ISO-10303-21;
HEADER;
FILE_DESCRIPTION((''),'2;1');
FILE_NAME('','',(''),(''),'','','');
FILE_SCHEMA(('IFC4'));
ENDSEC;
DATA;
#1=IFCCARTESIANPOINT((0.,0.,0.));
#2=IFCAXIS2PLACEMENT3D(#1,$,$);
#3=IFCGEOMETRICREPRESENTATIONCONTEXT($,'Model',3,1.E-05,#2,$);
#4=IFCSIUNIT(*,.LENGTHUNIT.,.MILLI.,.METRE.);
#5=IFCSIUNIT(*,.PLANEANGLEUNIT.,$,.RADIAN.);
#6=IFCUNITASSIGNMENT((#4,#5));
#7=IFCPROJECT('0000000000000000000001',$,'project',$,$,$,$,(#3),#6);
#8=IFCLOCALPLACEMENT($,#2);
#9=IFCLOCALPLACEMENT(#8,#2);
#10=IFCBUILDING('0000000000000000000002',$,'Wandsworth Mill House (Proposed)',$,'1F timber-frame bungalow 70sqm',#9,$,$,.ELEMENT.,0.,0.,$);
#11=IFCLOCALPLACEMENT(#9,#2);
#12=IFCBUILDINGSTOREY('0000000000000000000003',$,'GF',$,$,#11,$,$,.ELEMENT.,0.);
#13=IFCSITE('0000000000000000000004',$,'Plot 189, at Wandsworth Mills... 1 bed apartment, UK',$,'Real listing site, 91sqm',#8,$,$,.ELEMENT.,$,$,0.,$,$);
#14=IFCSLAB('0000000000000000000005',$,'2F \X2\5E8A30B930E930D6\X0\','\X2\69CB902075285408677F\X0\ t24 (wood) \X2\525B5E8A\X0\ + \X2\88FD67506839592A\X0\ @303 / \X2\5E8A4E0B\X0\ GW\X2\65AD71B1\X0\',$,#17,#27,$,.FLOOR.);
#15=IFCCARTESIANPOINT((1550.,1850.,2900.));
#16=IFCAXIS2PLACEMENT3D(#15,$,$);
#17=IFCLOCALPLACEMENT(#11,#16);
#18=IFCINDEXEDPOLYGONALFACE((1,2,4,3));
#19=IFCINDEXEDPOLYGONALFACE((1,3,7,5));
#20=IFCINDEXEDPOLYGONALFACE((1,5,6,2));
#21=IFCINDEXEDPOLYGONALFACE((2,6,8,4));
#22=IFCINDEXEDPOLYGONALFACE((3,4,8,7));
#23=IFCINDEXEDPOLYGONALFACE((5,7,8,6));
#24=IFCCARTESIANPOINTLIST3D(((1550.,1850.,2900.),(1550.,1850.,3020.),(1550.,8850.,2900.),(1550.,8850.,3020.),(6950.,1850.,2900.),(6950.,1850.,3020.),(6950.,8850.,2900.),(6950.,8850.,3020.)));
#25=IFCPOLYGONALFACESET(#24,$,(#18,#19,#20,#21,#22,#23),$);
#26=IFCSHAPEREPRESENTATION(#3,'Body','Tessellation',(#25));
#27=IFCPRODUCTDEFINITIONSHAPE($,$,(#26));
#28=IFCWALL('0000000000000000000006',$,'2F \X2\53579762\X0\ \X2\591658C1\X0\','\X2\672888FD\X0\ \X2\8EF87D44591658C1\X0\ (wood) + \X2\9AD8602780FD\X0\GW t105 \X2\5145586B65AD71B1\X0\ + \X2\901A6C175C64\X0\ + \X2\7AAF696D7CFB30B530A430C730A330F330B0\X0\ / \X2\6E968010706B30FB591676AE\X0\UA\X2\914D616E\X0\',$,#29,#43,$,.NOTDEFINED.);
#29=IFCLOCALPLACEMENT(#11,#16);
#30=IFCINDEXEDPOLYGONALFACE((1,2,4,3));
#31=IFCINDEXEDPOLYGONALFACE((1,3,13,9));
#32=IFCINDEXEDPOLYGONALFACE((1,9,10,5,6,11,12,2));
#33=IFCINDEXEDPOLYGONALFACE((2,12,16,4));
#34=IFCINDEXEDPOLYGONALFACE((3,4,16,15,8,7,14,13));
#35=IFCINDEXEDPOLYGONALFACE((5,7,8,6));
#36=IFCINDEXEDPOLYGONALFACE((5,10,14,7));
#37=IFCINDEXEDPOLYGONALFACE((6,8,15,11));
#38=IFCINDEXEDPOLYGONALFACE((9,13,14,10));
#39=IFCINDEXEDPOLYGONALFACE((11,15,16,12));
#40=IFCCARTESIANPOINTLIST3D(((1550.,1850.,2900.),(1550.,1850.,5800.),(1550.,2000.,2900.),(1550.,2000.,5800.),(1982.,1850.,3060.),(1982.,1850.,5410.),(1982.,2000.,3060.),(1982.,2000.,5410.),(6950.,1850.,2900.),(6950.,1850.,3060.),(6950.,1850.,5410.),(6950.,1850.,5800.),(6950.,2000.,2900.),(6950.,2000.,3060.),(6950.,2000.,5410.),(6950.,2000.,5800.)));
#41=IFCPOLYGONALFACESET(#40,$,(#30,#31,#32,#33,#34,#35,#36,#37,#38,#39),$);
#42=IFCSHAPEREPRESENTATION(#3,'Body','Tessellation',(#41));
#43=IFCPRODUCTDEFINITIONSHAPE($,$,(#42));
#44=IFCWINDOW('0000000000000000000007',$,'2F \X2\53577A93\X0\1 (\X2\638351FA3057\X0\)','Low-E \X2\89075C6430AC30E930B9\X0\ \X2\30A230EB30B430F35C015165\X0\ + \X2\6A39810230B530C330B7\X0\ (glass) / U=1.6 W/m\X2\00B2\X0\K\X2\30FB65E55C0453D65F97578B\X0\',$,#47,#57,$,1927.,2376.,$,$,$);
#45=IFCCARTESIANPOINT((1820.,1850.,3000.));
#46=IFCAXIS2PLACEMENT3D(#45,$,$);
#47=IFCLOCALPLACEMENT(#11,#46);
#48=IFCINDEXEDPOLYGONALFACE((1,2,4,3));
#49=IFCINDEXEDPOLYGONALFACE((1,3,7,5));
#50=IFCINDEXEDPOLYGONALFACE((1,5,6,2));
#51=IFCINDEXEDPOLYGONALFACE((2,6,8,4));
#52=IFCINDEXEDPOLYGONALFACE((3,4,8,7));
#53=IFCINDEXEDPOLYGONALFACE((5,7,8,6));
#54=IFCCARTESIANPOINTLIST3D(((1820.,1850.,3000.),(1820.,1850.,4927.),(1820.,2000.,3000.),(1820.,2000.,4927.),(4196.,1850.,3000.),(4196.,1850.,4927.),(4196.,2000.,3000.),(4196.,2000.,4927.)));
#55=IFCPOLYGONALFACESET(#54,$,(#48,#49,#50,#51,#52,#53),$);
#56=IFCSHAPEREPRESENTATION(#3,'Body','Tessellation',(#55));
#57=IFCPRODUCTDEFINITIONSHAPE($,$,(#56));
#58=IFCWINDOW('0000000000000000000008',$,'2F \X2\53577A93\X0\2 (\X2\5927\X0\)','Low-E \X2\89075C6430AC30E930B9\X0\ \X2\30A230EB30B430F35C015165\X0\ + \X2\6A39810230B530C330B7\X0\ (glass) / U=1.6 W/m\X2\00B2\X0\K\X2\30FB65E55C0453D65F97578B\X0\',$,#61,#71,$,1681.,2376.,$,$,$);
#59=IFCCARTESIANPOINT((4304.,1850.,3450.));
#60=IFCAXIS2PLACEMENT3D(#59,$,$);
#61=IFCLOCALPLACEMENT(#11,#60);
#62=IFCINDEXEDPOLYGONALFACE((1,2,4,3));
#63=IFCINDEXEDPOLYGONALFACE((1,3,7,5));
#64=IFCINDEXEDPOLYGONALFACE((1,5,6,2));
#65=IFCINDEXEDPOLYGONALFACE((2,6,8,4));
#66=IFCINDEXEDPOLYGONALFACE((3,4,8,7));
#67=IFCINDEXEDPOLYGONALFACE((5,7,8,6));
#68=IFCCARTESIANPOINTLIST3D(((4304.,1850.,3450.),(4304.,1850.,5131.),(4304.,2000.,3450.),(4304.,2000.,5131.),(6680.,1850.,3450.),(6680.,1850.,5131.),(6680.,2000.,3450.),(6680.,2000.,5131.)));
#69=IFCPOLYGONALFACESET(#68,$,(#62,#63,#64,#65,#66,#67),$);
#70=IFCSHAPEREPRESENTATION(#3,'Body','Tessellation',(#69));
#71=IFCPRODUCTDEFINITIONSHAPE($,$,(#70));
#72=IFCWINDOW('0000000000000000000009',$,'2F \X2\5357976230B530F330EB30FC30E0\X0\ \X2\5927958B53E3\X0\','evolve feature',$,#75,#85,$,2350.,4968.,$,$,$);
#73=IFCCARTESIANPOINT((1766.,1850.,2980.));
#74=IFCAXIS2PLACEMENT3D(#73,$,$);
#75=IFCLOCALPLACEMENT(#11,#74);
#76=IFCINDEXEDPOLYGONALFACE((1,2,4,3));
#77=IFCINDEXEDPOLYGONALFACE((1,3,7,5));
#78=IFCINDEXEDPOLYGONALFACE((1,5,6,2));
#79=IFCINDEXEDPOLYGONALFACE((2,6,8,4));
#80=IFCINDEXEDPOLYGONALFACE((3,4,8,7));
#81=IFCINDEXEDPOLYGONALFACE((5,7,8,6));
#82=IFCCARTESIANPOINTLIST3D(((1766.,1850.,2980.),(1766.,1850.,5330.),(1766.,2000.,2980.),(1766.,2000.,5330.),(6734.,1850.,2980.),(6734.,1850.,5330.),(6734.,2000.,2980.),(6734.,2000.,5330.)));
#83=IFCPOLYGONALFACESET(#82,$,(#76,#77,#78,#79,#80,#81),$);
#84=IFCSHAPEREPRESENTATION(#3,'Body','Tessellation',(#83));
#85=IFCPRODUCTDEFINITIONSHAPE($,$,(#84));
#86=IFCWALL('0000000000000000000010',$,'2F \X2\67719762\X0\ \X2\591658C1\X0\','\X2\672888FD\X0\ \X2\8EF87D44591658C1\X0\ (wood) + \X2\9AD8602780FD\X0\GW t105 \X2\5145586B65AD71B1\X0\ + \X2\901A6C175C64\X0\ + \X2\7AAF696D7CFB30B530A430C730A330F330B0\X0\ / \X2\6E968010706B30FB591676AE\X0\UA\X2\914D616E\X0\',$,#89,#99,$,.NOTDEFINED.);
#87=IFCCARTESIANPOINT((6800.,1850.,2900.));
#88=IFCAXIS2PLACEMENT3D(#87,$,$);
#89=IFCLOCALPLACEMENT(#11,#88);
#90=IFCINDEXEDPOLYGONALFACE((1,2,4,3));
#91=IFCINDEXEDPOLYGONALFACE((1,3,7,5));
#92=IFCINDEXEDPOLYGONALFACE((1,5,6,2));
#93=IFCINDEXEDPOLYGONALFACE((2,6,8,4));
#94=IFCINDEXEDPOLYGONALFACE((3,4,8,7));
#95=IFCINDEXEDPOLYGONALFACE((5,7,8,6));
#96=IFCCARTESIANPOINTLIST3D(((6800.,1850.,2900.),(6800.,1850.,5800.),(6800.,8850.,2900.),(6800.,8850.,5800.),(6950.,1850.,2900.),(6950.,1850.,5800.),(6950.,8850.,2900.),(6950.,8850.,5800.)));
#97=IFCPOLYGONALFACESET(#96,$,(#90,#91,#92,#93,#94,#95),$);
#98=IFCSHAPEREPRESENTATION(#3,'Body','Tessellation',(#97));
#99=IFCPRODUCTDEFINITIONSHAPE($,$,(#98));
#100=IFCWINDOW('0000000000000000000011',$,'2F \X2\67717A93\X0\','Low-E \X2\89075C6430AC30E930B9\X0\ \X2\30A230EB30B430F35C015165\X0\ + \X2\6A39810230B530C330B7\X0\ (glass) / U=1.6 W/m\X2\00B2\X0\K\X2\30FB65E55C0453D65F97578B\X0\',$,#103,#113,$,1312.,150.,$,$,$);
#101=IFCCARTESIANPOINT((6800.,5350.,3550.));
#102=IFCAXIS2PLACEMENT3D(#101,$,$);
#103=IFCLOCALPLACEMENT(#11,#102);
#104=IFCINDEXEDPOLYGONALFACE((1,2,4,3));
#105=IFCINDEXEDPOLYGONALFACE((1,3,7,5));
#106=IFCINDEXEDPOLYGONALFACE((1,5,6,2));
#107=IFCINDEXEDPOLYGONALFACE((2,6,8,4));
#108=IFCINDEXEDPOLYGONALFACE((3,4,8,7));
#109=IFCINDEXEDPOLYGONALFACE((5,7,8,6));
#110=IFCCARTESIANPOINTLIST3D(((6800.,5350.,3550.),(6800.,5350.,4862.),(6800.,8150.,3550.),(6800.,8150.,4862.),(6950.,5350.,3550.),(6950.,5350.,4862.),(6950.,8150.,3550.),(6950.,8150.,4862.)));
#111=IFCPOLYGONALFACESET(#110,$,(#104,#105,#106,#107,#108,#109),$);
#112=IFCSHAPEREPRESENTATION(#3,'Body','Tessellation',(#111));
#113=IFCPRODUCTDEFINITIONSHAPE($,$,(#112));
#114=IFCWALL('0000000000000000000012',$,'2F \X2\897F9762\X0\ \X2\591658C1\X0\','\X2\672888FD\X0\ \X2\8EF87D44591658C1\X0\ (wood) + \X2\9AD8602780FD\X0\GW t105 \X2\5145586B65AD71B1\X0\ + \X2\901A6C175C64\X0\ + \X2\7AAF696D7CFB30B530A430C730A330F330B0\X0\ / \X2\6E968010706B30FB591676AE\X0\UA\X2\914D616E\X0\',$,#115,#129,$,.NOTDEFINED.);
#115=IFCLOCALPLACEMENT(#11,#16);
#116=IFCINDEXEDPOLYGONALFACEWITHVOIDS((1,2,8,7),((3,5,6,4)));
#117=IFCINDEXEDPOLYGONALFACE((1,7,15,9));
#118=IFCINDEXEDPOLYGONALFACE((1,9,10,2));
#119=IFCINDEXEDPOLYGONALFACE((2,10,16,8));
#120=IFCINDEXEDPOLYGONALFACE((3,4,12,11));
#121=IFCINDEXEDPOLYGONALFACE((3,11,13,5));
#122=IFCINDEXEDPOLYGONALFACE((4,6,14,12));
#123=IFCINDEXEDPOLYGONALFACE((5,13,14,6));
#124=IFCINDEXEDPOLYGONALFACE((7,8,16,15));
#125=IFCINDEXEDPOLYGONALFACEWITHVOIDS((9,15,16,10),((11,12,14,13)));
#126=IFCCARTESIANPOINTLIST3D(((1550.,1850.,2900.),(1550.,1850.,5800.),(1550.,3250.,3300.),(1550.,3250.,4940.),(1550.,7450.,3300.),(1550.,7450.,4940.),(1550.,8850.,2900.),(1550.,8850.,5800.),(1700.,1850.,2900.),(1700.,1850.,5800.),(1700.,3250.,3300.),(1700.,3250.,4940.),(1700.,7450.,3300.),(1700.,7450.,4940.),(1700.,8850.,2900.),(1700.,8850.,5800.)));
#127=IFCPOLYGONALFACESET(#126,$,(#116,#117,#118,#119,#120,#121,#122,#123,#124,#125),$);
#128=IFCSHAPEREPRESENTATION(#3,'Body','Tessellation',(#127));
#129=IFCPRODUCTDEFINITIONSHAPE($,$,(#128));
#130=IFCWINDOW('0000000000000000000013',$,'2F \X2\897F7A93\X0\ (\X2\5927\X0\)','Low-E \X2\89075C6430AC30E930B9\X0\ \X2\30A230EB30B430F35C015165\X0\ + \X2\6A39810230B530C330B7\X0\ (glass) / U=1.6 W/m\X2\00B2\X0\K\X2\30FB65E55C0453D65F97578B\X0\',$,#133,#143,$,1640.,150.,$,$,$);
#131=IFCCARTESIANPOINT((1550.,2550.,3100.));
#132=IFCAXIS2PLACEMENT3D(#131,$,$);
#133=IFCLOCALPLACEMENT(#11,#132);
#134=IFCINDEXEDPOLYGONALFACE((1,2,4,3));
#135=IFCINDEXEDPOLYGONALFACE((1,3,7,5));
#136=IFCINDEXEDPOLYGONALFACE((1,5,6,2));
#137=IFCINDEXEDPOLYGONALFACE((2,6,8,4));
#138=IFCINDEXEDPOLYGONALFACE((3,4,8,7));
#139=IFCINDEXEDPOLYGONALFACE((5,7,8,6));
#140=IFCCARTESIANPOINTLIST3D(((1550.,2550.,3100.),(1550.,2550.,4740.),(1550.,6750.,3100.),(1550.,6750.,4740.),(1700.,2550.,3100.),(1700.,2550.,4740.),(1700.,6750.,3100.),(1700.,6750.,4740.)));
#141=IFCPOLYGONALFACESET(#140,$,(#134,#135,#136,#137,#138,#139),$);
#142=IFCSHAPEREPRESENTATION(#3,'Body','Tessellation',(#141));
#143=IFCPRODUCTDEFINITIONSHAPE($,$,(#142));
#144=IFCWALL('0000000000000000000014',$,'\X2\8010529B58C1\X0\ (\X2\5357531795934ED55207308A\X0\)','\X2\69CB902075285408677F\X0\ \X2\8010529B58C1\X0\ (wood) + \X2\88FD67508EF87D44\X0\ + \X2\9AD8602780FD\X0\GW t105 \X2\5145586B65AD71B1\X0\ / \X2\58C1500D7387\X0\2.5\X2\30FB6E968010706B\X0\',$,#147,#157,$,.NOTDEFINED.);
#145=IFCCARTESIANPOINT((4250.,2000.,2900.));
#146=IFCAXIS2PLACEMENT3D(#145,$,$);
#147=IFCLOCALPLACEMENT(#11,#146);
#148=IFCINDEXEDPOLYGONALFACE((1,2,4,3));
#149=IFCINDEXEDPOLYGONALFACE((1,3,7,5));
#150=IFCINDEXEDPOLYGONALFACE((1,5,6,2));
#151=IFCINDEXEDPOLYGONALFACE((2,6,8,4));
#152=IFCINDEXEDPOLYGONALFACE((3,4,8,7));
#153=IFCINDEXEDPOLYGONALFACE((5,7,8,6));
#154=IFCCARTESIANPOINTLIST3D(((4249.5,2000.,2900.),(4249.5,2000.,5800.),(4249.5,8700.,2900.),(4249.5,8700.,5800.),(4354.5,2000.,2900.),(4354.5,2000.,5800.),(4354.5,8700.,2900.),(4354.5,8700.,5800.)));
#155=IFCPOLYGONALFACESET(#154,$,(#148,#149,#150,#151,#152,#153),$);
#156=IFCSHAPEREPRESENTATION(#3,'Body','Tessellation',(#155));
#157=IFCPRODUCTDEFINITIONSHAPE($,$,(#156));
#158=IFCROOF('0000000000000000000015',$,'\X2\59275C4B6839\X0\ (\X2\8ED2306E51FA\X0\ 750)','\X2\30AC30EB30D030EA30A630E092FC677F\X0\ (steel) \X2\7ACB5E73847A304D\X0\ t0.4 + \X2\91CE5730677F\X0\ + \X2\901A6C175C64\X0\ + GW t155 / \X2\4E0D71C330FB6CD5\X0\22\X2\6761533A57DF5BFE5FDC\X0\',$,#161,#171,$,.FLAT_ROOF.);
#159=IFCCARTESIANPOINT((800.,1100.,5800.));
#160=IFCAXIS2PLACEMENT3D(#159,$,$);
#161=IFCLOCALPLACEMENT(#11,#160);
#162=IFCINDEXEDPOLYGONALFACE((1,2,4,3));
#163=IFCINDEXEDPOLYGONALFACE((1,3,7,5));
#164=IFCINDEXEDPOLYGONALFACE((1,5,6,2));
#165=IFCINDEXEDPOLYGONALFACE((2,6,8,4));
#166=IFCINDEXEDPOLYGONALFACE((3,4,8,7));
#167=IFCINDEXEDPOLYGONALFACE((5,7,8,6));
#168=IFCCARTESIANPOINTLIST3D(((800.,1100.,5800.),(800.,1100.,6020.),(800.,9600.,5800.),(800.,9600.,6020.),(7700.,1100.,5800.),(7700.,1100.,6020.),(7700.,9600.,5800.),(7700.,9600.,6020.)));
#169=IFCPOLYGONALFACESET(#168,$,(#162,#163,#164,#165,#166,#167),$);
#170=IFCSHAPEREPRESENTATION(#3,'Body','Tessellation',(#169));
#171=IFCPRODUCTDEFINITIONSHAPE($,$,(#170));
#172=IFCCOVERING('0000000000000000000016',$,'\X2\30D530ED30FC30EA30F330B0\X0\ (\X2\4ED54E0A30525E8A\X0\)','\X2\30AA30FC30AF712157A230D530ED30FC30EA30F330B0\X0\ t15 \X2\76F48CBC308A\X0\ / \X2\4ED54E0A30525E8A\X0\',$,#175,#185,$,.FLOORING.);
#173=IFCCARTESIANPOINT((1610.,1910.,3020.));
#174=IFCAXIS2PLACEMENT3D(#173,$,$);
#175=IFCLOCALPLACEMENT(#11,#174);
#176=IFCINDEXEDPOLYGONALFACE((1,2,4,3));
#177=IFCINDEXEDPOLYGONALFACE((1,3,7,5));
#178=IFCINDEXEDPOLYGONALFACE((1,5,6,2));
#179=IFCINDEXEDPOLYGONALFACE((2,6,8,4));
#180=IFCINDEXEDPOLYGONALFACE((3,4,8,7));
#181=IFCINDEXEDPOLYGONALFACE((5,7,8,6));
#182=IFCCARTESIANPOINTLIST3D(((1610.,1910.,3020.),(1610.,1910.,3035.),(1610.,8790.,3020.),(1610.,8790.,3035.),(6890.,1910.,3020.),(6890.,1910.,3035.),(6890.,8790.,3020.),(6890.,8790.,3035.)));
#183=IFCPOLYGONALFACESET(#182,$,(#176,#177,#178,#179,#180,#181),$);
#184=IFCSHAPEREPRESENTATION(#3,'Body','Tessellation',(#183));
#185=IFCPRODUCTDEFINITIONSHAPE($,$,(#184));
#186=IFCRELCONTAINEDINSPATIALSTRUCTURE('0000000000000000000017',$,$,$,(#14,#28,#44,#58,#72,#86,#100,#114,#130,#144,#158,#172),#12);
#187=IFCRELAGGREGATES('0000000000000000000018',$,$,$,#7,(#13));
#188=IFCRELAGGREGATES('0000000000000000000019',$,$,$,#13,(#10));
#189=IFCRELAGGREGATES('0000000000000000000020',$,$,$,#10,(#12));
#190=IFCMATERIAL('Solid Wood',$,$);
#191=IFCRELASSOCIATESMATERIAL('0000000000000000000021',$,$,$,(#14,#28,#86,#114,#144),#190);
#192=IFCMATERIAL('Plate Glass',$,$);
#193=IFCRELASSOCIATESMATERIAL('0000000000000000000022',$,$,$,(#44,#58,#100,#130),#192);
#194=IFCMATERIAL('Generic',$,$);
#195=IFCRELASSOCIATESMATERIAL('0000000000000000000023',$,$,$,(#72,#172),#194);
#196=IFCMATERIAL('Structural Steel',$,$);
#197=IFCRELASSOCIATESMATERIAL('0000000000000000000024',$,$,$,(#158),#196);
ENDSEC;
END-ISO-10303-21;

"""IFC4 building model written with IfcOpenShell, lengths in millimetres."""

from ifc_helpers import new_model, si_unit, frame, frame_2d, origin, place, context, project, spatial, rectangle, extrude, material, element, fill, save


model = new_model("IFC4")

# Units and contexts
model_context = context("Model", 3, precision=1e-05, world=origin())
ifc_project = project(units=[si_unit("LENGTHUNIT", "METRE", prefix="MILLI"), si_unit("PLANEANGLEUNIT", "RADIAN")], contexts=[model_context])

# Site, building, storey
site_placement = place(None, origin())
site = spatial("IfcSite", under=ifc_project, at=site_placement, Name="Plot 189, at Wandsworth Mills... 1 bed apartment, UK", ObjectType="Real listing site, 91sqm", CompositionType="ELEMENT", RefElevation=0.0)
building_placement = place(site_placement, origin())
building = spatial("IfcBuilding", under=site, at=building_placement, Name="Wandsworth Mill House (Proposed)", ObjectType="1F timber-frame bungalow 70sqm", CompositionType="ELEMENT", ElevationOfRefHeight=0.0, ElevationOfTerrain=0.0)
storey_placement = place(building_placement, origin())
storey = spatial("IfcBuildingStorey", under=building, at=storey_placement, Name="GF", CompositionType="ELEMENT", Elevation=0.0)

# Slab
ifc_material_1 = material(Name="Solid Wood")
slab_placement = place(storey_placement, frame((1550.0, 1850.0, 2900.0)))
element("IfcSlab", 1, at=slab_placement, inside=storey, material=ifc_material_1, Name="2F 床スラブ", Description="構造用合板 t24 (wood) 剛床 + 製材根太 @303 / 床下 GW断熱", PredefinedType="FLOOR", context=model_context, shape_type="SweptSolid", body=[
    extrude(rectangle(XDim=5400.0, YDim=7000.0, at=frame_2d((2700.0, 3500.0))), frame((1550.0, 1850.0, 2900.0)), (0.0, 0.0, 1.0), 120.0),
])

# Wall, openings, windows
wall_1_placement = place(storey_placement, frame((1550.0, 1850.0, 2900.0)))
wall_1 = element("IfcWall", 2, at=wall_1_placement, inside=storey, material=ifc_material_1, Name="2F 南面 外壁", Description="木製 軸組外壁 (wood) + 高性能GW t105 充填断熱 + 通気層 + 窯業系サイディング / 準耐火・外皮UA配慮", PredefinedType="NOTDEFINED", context=model_context, shape_type="SweptSolid", body=[
    extrude(rectangle(XDim=5400.0, YDim=150.0, at=frame_2d((2700.0, 75.0))), frame((1550.0, 1850.0, 2900.0)), (0.0, 0.0, 1.0), 2900.0),
])
opening_1_placement = place(storey_placement, frame((1820.0, 1850.0, 3000.0)))
opening_1 = element("IfcOpeningElement", 3, at=opening_1_placement, cuts=wall_1, PredefinedType="NOTDEFINED", context=model_context, shape_type="SweptSolid", body=[
    extrude(rectangle(XDim=2376.0, YDim=150.0, at=frame_2d((1188.0, 75.0))), frame((1820.0, 1850.0, 3000.0)), (0.0, 0.0, 1.0), 1927.0),
])
opening_2_placement = place(storey_placement, frame((4304.0, 1850.0, 3450.0)))
opening_2 = element("IfcOpeningElement", 4, at=opening_2_placement, cuts=wall_1, PredefinedType="NOTDEFINED", context=model_context, shape_type="SweptSolid", body=[
    extrude(rectangle(XDim=2376.0, YDim=150.0, at=frame_2d((1188.0, 75.0))), frame((4304.0, 1850.0, 3450.0)), (0.0, 0.0, 1.0), 1681.0),
])
opening_3_placement = place(storey_placement, frame((1766.0, 1850.0, 2980.0)))
opening_3 = element("IfcOpeningElement", 5, at=opening_3_placement, cuts=wall_1, PredefinedType="NOTDEFINED", context=model_context, shape_type="SweptSolid", body=[
    extrude(rectangle(XDim=4968.0, YDim=150.0, at=frame_2d((2484.0, 75.0))), frame((1766.0, 1850.0, 2980.0)), (0.0, 0.0, 1.0), 2350.0),
])
ifc_material_2 = material(Name="Plate Glass")
window_1_placement = place(storey_placement, frame((1820.0, 1850.0, 3000.0)))
window_1 = element("IfcWindow", 6, at=window_1_placement, inside=storey, material=ifc_material_2, Name="2F 南窓1 (掃出し)", Description="Low-E 複層ガラス アルゴン封入 + 樹脂サッシ (glass) / U=1.6 W/m²K・日射取得型", OverallHeight=1927.0, OverallWidth=2376.0, context=model_context, shape_type="SweptSolid", body=[
    extrude(rectangle(XDim=2376.0, YDim=150.0, at=frame_2d((1188.0, 75.0))), frame((1820.0, 1850.0, 3000.0)), (0.0, 0.0, 1.0), 1927.0),
])
fill(opening_1, window_1)
window_2_placement = place(storey_placement, frame((4304.0, 1850.0, 3450.0)))
window_2 = element("IfcWindow", 7, at=window_2_placement, inside=storey, material=ifc_material_2, Name="2F 南窓2 (大)", Description="Low-E 複層ガラス アルゴン封入 + 樹脂サッシ (glass) / U=1.6 W/m²K・日射取得型", OverallHeight=1681.0, OverallWidth=2376.0, context=model_context, shape_type="SweptSolid", body=[
    extrude(rectangle(XDim=2376.0, YDim=150.0, at=frame_2d((1188.0, 75.0))), frame((4304.0, 1850.0, 3450.0)), (0.0, 0.0, 1.0), 1681.0),
])
fill(opening_2, window_2)
ifc_material_3 = material(Name="Generic")
window_3_placement = place(storey_placement, frame((1766.0, 1850.0, 2980.0)))
window_3 = element("IfcWindow", 8, at=window_3_placement, inside=storey, material=ifc_material_3, Name="2F 南面サンルーム 大開口", Description="evolve feature", OverallHeight=2350.0, OverallWidth=4968.0, context=model_context, shape_type="SweptSolid", body=[
    extrude(rectangle(XDim=4968.0, YDim=150.0, at=frame_2d((2484.0, 75.0))), frame((1766.0, 1850.0, 2980.0)), (0.0, 0.0, 1.0), 2350.0),
])
fill(opening_3, window_3)

# Walls, openings, windows
wall_2_placement = place(storey_placement, frame((6800.0, 1850.0, 2900.0)))
wall_2 = element("IfcWall", 9, at=wall_2_placement, inside=storey, material=ifc_material_1, Name="2F 東面 外壁", Description="木製 軸組外壁 (wood) + 高性能GW t105 充填断熱 + 通気層 + 窯業系サイディング / 準耐火・外皮UA配慮", PredefinedType="NOTDEFINED", context=model_context, shape_type="SweptSolid", body=[
    extrude(rectangle(XDim=150.0, YDim=7000.0, at=frame_2d((75.0, 3500.0))), frame((6800.0, 1850.0, 2900.0)), (0.0, 0.0, 1.0), 2900.0),
])
opening_4_placement = place(storey_placement, frame((6800.0, 5350.0, 3550.0)))
opening_4 = element("IfcOpeningElement", 10, at=opening_4_placement, cuts=wall_2, PredefinedType="NOTDEFINED", context=model_context, shape_type="SweptSolid", body=[
    extrude(rectangle(XDim=150.0, YDim=2800.0, at=frame_2d((75.0, 1400.0))), frame((6800.0, 5350.0, 3550.0)), (0.0, 0.0, 1.0), 1312.0),
])
window_4_placement = place(storey_placement, frame((6800.0, 5350.0, 3550.0)))
window_4 = element("IfcWindow", 11, at=window_4_placement, inside=storey, material=ifc_material_2, Name="2F 東窓", Description="Low-E 複層ガラス アルゴン封入 + 樹脂サッシ (glass) / U=1.6 W/m²K・日射取得型", OverallHeight=1312.0, OverallWidth=150.0, context=model_context, shape_type="SweptSolid", body=[
    extrude(rectangle(XDim=150.0, YDim=2800.0, at=frame_2d((75.0, 1400.0))), frame((6800.0, 5350.0, 3550.0)), (0.0, 0.0, 1.0), 1312.0),
])
fill(opening_4, window_4)
wall_3_placement = place(storey_placement, frame((1550.0, 1850.0, 2900.0)))
wall_3 = element("IfcWall", 12, at=wall_3_placement, inside=storey, material=ifc_material_1, Name="2F 西面 外壁", Description="木製 軸組外壁 (wood) + 高性能GW t105 充填断熱 + 通気層 + 窯業系サイディング / 準耐火・外皮UA配慮", PredefinedType="NOTDEFINED", context=model_context, shape_type="SweptSolid", body=[
    extrude(rectangle(XDim=150.0, YDim=7000.0, at=frame_2d((75.0, 3500.0))), frame((1550.0, 1850.0, 2900.0)), (0.0, 0.0, 1.0), 2900.0),
])
opening_5_placement = place(storey_placement, frame((1550.0, 2550.0, 3100.0)))
opening_5 = element("IfcOpeningElement", 13, at=opening_5_placement, cuts=wall_3, PredefinedType="NOTDEFINED", context=model_context, shape_type="SweptSolid", body=[
    extrude(rectangle(XDim=150.0, YDim=4200.0, at=frame_2d((75.0, 2100.0))), frame((1550.0, 2550.0, 3100.0)), (0.0, 0.0, 1.0), 1640.0),
])
window_5_placement = place(storey_placement, frame((1550.0, 2550.0, 3100.0)))
window_5 = element("IfcWindow", 14, at=window_5_placement, inside=storey, material=ifc_material_2, Name="2F 西窓 (大)", Description="Low-E 複層ガラス アルゴン封入 + 樹脂サッシ (glass) / U=1.6 W/m²K・日射取得型", OverallHeight=1640.0, OverallWidth=150.0, context=model_context, shape_type="SweptSolid", body=[
    extrude(rectangle(XDim=150.0, YDim=4200.0, at=frame_2d((75.0, 2100.0))), frame((1550.0, 2550.0, 3100.0)), (0.0, 0.0, 1.0), 1640.0),
])
fill(opening_5, window_5)

# Wall
wall_4_placement = place(storey_placement, frame((4250.0, 2000.0, 2900.0)))
element("IfcWall", 15, at=wall_4_placement, inside=storey, material=ifc_material_1, Name="耐力壁 (南北間仕切り)", Description="構造用合板 耐力壁 (wood) + 製材軸組 + 高性能GW t105 充填断熱 / 壁倍率2.5・準耐火", PredefinedType="NOTDEFINED", context=model_context, shape_type="SweptSolid", body=[
    extrude(rectangle(XDim=105.0, YDim=6700.0, at=frame_2d((52.0, 3350.0))), frame((4250.0, 2000.0, 2900.0)), (0.0, 0.0, 1.0), 2900.0),
])

# Roof
ifc_material_4 = material(Name="Structural Steel")
roof_placement = place(storey_placement, frame((800.0, 1100.0, 5800.0)))
element("IfcRoof", 16, at=roof_placement, inside=storey, material=ifc_material_4, Name="大屋根 (軒の出 750)", Description="ガルバリウム鋼板 (steel) 立平葺き t0.4 + 野地板 + 通気層 + GW t155 / 不燃・法22条区域対応", PredefinedType="FLAT_ROOF", context=model_context, shape_type="SweptSolid", body=[
    extrude(rectangle(XDim=6900.0, YDim=8500.0, at=frame_2d((3450.0, 4250.0))), frame((800.0, 1100.0, 5800.0)), (0.0, 0.0, 1.0), 220.0),
])

# Covering
covering_placement = place(storey_placement, frame((1610.0, 1910.0, 3020.0)))
element("IfcCovering", 17, at=covering_placement, inside=storey, material=ifc_material_3, Name="フローリング (仕上げ床)", Description="オーク無垢フローリング t15 直貼り / 仕上げ床", PredefinedType="FLOORING", context=model_context, shape_type="SweptSolid", body=[
    extrude(rectangle(XDim=5280.0, YDim=6880.0, at=frame_2d((2640.0, 3440.0))), frame((1610.0, 1910.0, 3020.0)), (0.0, 0.0, 1.0), 15.0),
])

save(model, "model.ifc")
